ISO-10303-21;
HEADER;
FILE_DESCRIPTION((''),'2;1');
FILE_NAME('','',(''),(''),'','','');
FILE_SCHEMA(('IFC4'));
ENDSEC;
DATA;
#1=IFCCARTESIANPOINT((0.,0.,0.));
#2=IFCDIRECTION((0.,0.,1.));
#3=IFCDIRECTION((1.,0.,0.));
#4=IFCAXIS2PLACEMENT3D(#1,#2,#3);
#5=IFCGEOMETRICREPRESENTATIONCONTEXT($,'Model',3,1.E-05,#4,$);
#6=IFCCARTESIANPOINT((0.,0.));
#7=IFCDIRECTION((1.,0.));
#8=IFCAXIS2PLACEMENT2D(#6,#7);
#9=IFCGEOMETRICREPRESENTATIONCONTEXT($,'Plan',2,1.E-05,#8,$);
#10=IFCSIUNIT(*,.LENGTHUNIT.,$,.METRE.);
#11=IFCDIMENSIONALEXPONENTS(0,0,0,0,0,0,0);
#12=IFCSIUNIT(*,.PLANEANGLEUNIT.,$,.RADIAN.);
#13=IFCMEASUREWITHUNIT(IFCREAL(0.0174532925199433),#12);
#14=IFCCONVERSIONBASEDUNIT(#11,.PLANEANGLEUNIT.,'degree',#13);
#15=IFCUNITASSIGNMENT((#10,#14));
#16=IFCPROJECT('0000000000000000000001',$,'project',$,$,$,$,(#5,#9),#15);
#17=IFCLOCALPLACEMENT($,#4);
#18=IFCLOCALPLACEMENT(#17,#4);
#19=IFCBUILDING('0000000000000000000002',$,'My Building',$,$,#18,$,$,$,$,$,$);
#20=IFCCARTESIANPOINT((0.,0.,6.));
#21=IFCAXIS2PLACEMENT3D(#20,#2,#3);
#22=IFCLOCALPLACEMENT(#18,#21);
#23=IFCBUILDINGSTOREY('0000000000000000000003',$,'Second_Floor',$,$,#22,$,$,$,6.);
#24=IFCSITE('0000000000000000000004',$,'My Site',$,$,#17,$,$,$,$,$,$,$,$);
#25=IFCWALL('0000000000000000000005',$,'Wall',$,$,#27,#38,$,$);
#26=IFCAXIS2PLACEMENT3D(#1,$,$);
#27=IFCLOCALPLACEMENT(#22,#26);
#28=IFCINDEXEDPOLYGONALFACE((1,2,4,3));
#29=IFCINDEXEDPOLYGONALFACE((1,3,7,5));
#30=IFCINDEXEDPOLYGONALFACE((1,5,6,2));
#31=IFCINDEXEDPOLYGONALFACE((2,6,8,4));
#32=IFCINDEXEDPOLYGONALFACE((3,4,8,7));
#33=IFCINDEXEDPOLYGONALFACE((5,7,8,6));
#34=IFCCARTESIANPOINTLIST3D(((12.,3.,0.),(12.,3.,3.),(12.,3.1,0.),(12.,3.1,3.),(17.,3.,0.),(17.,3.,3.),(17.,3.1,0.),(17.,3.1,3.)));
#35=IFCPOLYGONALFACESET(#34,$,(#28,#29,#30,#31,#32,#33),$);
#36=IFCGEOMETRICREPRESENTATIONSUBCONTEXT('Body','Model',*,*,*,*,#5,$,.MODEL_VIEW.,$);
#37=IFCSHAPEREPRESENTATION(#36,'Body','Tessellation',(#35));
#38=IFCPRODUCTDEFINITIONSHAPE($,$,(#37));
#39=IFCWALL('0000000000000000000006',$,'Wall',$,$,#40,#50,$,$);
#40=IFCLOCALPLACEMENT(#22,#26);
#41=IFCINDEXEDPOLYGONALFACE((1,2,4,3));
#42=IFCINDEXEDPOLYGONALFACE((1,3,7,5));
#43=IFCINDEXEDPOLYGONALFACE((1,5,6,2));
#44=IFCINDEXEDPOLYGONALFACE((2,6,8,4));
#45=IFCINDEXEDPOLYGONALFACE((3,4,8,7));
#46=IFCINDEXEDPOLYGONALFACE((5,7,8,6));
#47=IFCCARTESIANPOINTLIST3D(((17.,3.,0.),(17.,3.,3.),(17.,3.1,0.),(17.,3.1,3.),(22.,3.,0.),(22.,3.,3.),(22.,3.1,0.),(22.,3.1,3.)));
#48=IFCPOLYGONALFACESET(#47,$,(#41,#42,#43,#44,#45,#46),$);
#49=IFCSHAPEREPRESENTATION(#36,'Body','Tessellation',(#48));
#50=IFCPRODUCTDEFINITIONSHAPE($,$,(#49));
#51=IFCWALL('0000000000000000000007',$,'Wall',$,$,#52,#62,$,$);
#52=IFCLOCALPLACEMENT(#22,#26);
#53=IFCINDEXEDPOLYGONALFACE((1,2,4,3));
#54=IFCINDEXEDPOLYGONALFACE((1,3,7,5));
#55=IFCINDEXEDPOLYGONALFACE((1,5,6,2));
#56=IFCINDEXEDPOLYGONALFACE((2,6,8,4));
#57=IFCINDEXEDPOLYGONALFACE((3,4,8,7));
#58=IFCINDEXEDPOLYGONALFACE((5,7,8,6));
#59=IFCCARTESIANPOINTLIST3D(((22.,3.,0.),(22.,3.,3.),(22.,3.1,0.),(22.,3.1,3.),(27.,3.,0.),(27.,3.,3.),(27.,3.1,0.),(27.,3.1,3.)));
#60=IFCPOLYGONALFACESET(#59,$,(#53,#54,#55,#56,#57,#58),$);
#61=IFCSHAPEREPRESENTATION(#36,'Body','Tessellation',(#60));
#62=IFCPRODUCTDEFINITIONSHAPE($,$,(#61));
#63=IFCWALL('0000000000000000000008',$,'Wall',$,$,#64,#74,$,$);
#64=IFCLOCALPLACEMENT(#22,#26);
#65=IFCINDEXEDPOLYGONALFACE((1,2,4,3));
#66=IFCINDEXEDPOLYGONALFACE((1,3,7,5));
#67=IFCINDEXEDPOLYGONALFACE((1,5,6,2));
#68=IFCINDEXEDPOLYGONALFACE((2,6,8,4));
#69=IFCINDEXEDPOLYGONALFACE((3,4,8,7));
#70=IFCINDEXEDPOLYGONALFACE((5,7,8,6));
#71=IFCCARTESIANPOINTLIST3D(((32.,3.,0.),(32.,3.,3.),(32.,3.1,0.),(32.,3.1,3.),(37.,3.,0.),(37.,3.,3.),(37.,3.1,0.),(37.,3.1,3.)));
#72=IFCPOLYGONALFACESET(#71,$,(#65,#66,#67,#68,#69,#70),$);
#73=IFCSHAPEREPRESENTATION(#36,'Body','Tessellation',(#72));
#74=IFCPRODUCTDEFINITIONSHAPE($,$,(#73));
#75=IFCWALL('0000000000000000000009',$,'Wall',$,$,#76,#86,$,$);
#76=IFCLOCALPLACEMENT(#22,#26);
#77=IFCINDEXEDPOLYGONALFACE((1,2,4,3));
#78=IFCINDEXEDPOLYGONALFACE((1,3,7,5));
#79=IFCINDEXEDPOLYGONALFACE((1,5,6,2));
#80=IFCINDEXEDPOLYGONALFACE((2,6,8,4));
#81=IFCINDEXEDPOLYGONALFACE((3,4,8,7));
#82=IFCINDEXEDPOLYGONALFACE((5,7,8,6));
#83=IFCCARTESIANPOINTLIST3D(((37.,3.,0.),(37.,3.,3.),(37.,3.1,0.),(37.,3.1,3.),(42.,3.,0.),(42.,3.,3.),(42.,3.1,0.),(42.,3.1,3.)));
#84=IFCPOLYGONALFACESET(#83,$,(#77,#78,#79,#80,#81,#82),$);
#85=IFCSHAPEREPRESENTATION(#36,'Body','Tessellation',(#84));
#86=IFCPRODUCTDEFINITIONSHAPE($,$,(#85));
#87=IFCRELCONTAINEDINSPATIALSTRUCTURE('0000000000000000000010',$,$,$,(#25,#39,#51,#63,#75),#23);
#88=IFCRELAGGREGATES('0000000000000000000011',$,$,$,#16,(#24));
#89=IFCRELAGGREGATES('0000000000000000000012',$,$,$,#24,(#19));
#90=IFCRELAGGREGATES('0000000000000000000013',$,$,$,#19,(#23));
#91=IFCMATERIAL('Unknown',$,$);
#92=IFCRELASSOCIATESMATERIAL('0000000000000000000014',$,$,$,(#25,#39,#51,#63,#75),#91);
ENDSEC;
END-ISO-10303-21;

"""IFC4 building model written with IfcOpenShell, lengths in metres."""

from ifc_helpers import new_model, entity, si_unit, converted_unit, frame, frame_2d, origin, origin_with_axes, origin_2d_with_axis, place, context, subcontext, project, spatial, rectangle, extrude, material, element, save


model = new_model("IFC4")

# Units and contexts
model_context = context("Model", 3, precision=1e-05, world=origin_with_axes())
plan_context = context("Plan", 2, precision=1e-05, world=origin_2d_with_axis())
body_context = subcontext(model_context, "Body", "Model", "MODEL_VIEW")
ifc_project = project(units=[si_unit("LENGTHUNIT", "METRE"), converted_unit("PLANEANGLEUNIT", "degree", entity("IfcReal", 0.0174532925199433), si_unit("PLANEANGLEUNIT", "RADIAN"), dimensions=[0, 0, 0, 0, 0, 0, 0])], contexts=[model_context, plan_context])

# Site, building, storey
site_placement = place(None, origin_with_axes())
site = spatial("IfcSite", under=ifc_project, at=site_placement, Name="My Site")
building_placement = place(site_placement, origin_with_axes())
building = spatial("IfcBuilding", under=site, at=building_placement, Name="My Building")
storey_placement = place(building_placement, frame((0.0, 0.0, 6.0), z_axis=(0.0, 0.0, 1.0), x_axis=(1.0, 0.0, 0.0)))
storey = spatial("IfcBuildingStorey", under=building, at=storey_placement, Name="Second_Floor", Elevation=6.0)

# Walls
ifc_material = material(Name="Unknown")
wall_1_placement = place(storey_placement, origin_with_axes())
element("IfcWall", 1, at=wall_1_placement, inside=storey, material=ifc_material, Name="Wall", context=body_context, shape_type="SweptSolid", body=[
    extrude(rectangle(XDim=5.0, YDim=0.1, at=frame_2d((14.5, 3.05))), origin(), (0.0, 0.0, 1.0), 3.0),
])
wall_2_placement = place(storey_placement, origin_with_axes())
element("IfcWall", 2, at=wall_2_placement, inside=storey, material=ifc_material, Name="Wall", context=body_context, shape_type="SweptSolid", body=[
    extrude(rectangle(XDim=5.0, YDim=0.1, at=frame_2d((19.5, 3.05))), origin(), (0.0, 0.0, 1.0), 3.0),
])
wall_3_placement = place(storey_placement, origin_with_axes())
element("IfcWall", 3, at=wall_3_placement, inside=storey, material=ifc_material, Name="Wall", context=body_context, shape_type="SweptSolid", body=[
    extrude(rectangle(XDim=5.0, YDim=0.1, at=frame_2d((24.5, 3.05))), origin(), (0.0, 0.0, 1.0), 3.0),
])
wall_4_placement = place(storey_placement, origin_with_axes())
element("IfcWall", 4, at=wall_4_placement, inside=storey, material=ifc_material, Name="Wall", context=body_context, shape_type="SweptSolid", body=[
    extrude(rectangle(XDim=5.0, YDim=0.1, at=frame_2d((34.5, 3.05))), origin(), (0.0, 0.0, 1.0), 3.0),
])
wall_5_placement = place(storey_placement, origin_with_axes())
element("IfcWall", 5, at=wall_5_placement, inside=storey, material=ifc_material, Name="Wall", context=body_context, shape_type="SweptSolid", body=[
    extrude(rectangle(XDim=5.0, YDim=0.1, at=frame_2d((39.5, 3.05))), origin(), (0.0, 0.0, 1.0), 3.0),
])

save(model, "model.ifc")
